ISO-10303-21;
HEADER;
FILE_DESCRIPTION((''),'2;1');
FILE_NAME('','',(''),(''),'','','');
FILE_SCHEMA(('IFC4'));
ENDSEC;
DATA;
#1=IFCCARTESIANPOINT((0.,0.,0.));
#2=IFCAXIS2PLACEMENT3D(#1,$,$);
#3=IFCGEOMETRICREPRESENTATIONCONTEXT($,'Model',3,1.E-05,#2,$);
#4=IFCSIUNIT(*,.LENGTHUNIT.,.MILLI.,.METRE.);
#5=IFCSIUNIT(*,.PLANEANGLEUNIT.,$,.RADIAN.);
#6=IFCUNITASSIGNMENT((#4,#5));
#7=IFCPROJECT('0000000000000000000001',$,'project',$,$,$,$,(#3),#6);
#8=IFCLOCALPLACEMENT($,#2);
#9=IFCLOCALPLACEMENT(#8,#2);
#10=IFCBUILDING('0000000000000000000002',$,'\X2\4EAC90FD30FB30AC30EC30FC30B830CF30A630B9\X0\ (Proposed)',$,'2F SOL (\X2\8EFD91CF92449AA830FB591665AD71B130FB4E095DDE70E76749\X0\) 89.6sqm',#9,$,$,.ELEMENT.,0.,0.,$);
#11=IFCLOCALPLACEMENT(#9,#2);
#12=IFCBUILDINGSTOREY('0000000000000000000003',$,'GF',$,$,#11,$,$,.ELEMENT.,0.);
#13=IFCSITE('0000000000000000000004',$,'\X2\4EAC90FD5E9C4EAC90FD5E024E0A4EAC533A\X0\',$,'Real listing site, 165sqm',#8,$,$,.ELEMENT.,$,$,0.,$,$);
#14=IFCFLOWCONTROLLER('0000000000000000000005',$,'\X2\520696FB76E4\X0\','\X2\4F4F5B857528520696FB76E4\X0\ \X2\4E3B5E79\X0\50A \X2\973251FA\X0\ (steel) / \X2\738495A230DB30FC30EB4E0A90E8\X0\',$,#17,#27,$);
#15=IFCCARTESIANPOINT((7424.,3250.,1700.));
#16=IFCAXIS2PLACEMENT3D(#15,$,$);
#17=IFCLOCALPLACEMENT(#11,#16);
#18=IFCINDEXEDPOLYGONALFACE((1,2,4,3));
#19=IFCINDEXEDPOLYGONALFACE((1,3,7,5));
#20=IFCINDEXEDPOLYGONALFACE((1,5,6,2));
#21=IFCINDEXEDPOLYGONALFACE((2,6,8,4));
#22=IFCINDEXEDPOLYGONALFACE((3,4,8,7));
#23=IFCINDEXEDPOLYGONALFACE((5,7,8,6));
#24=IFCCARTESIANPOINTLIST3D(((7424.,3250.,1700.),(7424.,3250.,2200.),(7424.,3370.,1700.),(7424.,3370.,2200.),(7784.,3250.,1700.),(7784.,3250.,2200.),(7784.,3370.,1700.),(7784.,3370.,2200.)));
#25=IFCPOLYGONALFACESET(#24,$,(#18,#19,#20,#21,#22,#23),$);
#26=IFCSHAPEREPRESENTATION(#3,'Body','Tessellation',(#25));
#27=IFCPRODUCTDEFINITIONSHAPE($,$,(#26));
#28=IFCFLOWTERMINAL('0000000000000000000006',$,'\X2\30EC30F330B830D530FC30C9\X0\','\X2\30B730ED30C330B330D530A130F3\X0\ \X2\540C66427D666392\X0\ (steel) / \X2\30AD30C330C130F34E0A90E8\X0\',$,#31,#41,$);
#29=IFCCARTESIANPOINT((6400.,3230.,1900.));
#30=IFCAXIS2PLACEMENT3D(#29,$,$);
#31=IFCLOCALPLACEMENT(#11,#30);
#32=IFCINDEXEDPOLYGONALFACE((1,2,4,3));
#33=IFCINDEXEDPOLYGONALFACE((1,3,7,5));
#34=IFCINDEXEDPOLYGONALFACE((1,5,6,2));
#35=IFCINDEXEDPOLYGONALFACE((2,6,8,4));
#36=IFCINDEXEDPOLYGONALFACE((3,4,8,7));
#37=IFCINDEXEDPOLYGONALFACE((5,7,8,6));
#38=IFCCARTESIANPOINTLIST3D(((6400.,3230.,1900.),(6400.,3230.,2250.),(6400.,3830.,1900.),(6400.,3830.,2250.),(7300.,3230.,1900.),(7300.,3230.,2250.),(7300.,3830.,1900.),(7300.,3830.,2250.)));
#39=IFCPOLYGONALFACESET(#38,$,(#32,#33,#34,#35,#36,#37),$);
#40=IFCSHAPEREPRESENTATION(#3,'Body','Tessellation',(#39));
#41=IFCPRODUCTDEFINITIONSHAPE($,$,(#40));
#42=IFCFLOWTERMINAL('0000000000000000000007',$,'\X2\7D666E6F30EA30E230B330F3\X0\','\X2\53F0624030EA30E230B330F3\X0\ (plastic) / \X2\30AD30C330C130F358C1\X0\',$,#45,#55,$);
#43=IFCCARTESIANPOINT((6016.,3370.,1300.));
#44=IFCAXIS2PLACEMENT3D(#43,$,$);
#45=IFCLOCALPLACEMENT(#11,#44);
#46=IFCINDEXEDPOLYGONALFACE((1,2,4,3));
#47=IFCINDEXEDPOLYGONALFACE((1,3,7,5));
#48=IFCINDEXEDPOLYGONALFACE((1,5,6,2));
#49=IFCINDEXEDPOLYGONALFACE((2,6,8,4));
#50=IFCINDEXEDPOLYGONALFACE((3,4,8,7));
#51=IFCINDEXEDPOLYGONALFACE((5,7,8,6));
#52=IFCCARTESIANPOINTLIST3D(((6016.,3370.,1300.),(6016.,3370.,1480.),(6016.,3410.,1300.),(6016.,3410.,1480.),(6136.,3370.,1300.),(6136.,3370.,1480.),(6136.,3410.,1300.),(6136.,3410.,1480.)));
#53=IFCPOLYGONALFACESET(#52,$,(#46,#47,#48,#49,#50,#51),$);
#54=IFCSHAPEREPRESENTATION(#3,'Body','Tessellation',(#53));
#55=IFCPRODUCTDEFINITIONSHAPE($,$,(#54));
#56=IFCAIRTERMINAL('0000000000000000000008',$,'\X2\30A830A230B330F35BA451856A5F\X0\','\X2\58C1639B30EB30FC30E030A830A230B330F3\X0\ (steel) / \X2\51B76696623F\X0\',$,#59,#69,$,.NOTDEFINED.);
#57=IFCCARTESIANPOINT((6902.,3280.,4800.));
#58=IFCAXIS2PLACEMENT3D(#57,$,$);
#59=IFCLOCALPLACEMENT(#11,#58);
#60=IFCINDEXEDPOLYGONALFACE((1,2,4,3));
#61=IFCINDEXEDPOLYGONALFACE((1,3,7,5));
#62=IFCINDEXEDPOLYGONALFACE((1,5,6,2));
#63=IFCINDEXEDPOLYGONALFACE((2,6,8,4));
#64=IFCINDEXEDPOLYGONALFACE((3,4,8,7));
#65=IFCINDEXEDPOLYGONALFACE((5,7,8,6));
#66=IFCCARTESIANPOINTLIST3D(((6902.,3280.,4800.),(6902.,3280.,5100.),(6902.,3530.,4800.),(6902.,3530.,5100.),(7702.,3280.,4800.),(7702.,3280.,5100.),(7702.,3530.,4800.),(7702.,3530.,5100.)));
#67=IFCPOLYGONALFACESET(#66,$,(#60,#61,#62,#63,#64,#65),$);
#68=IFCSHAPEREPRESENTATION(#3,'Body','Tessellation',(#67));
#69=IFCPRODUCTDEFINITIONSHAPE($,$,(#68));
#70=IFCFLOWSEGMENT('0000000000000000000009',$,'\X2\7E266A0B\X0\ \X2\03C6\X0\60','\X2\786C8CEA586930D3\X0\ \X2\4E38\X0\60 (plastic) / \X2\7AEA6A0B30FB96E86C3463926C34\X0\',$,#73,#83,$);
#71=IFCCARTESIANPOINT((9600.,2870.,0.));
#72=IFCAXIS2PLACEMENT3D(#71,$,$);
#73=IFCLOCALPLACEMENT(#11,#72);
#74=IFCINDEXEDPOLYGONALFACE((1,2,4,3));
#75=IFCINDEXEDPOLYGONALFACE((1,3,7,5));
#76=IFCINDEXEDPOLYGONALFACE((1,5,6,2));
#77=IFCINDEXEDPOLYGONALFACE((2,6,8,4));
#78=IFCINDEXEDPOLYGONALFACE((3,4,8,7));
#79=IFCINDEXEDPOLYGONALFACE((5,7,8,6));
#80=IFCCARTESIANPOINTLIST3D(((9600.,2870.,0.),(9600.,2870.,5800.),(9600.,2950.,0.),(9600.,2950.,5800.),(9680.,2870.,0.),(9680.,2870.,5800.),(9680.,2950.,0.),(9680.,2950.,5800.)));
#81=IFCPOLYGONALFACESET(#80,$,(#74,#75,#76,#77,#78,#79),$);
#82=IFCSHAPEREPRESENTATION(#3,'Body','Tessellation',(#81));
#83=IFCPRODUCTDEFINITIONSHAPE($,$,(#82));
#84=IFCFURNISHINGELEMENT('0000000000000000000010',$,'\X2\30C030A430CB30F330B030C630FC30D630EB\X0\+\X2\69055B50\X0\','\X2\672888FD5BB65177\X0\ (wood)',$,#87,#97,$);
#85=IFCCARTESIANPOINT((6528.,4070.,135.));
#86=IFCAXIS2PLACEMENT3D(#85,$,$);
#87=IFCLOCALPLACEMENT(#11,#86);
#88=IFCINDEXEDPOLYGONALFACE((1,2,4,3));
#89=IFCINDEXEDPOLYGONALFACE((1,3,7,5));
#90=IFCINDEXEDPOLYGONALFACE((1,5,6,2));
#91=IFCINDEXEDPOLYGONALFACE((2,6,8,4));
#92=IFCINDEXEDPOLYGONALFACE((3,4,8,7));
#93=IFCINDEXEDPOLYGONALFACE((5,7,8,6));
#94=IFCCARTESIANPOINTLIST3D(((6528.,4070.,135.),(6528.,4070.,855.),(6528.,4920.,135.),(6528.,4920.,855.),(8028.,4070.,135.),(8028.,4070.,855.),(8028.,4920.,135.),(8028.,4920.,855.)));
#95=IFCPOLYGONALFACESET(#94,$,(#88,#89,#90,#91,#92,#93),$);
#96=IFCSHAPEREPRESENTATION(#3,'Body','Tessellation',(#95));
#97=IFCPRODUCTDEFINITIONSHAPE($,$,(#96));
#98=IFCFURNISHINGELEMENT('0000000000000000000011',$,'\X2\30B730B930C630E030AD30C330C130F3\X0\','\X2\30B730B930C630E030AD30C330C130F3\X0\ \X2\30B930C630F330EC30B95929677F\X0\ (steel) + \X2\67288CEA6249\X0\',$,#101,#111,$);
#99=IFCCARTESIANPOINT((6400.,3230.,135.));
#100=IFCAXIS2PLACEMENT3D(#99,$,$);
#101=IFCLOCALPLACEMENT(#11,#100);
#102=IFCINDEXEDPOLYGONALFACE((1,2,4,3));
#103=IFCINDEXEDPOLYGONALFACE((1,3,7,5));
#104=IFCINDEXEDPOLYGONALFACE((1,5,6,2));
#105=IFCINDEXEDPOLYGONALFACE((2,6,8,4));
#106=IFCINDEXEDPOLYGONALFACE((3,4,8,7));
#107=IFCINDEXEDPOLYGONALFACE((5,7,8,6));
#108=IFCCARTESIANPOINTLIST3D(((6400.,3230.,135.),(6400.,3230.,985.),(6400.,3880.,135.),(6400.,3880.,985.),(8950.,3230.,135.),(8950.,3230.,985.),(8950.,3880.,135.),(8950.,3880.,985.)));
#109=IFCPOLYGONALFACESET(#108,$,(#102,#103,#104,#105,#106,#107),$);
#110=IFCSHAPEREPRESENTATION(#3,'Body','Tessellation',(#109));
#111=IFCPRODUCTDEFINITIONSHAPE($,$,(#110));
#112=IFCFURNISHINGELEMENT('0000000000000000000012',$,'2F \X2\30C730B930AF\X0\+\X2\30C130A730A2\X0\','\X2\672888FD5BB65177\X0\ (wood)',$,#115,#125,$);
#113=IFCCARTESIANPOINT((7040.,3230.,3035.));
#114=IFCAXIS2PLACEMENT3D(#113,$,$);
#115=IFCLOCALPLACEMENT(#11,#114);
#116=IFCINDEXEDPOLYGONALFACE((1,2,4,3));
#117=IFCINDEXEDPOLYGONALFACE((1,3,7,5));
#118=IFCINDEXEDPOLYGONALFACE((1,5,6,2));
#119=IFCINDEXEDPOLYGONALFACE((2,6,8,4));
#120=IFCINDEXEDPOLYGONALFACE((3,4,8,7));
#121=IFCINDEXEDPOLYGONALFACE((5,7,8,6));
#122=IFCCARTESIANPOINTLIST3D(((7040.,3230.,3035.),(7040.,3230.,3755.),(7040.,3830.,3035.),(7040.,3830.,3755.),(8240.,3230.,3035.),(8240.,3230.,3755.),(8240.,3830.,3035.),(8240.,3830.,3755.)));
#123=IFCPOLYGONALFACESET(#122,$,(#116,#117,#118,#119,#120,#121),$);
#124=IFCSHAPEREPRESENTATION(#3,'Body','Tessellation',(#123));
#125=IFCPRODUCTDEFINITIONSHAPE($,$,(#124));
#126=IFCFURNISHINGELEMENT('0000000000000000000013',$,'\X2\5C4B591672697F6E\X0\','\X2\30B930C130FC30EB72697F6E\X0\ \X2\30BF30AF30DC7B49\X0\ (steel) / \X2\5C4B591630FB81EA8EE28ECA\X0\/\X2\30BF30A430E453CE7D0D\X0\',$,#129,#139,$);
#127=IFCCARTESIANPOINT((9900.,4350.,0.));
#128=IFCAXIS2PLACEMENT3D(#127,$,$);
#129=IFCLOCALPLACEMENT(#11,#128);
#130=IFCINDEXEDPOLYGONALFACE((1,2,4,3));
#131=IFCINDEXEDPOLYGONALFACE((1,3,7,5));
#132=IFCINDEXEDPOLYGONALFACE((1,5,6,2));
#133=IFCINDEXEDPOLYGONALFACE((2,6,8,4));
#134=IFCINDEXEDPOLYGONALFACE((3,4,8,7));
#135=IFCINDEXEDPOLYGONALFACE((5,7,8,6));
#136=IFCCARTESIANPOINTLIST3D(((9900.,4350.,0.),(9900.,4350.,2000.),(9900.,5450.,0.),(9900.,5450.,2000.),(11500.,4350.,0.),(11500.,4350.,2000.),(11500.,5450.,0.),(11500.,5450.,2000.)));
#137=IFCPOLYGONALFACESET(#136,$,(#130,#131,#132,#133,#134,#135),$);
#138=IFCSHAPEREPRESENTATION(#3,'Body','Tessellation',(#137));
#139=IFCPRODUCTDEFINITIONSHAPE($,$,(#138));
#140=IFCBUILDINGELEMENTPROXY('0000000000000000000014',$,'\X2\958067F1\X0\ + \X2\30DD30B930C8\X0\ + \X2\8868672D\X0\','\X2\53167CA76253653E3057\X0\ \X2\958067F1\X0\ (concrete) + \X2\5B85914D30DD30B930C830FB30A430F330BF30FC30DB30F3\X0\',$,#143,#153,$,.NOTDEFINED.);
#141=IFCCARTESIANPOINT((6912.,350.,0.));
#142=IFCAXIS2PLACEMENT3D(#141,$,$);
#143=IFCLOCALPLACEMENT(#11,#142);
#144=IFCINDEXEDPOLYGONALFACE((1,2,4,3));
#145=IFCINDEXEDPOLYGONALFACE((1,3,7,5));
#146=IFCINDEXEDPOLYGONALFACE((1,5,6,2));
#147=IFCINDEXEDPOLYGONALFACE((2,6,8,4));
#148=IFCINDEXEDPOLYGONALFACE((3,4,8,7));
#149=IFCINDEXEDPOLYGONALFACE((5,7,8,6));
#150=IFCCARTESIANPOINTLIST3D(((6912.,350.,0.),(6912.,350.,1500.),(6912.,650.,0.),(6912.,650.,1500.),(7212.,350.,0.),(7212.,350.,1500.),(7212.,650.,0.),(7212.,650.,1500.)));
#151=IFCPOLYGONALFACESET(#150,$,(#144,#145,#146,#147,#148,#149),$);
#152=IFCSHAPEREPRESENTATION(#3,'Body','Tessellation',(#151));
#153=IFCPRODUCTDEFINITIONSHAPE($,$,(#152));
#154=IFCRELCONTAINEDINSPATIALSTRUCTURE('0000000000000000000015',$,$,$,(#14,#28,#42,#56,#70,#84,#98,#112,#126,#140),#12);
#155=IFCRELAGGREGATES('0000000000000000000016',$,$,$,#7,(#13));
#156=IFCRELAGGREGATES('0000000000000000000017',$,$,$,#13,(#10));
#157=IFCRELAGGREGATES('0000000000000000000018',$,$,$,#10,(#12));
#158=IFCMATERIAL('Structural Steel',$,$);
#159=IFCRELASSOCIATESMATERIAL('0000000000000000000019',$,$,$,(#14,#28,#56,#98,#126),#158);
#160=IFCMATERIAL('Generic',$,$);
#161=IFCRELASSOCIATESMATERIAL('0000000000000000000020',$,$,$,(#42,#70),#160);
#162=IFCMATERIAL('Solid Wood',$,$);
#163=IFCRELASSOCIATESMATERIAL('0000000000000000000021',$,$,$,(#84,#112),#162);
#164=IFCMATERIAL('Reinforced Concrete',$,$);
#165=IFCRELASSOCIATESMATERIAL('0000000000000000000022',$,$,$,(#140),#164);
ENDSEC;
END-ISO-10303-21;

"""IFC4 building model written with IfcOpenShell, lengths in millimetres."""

from ifc_helpers import new_model, si_unit, frame, frame_2d, origin, place, context, project, spatial, rectangle, extrude, material, element, save


model = new_model("IFC4")

# Units and contexts
model_context = context("Model", 3, precision=1e-05, world=origin())
ifc_project = project(units=[si_unit("LENGTHUNIT", "METRE", prefix="MILLI"), si_unit("PLANEANGLEUNIT", "RADIAN")], contexts=[model_context])

# Site, building, storey
site_placement = place(None, origin())
site = spatial("IfcSite", under=ifc_project, at=site_placement, Name="京都府京都市上京区", ObjectType="Real listing site, 165sqm", CompositionType="ELEMENT", RefElevation=0.0)
building_placement = place(site_placement, origin())
building = spatial("IfcBuilding", under=site, at=building_placement, Name="京都・ガレージハウス (Proposed)", ObjectType="2F SOL (軽量鉄骨・外断熱・三州烧杉) 89.6sqm", CompositionType="ELEMENT", ElevationOfRefHeight=0.0, ElevationOfTerrain=0.0)
storey_placement = place(building_placement, origin())
storey = spatial("IfcBuildingStorey", under=building, at=storey_placement, Name="GF", CompositionType="ELEMENT", Elevation=0.0)

# Shared definitions
ifc_material_1 = material(Name="Solid Wood")
ifc_material_2 = material(Name="Structural Steel")

# Shared definitions
ifc_material_3 = material(Name="Reinforced Concrete")

# Flow controller
flow_controller_placement = place(storey_placement, frame((7424.0, 3250.0, 1700.0)))
element("IfcFlowController", 1, at=flow_controller_placement, inside=storey, material=ifc_material_2, Name="分電盤", Description="住宅用分電盤 主幹50A 露出 (steel) / 玄関ホール上部", context=model_context, shape_type="SweptSolid", body=[
    extrude(rectangle(XDim=360.0, YDim=120.0, at=frame_2d((180.0, 60.0))), frame((7424.0, 3250.0, 1700.0)), (0.0, 0.0, 1.0), 500.0),
])

# Flow terminals
flow_terminal_1_placement = place(storey_placement, frame((6400.0, 3230.0, 1900.0)))
element("IfcFlowTerminal", 2, at=flow_terminal_1_placement, inside=storey, material=ifc_material_2, Name="レンジフード", Description="シロッコファン 同時給排 (steel) / キッチン上部", context=model_context, shape_type="SweptSolid", body=[
    extrude(rectangle(XDim=900.0, YDim=600.0, at=frame_2d((450.0, 300.0))), frame((6400.0, 3230.0, 1900.0)), (0.0, 0.0, 1.0), 350.0),
])
ifc_material_4 = material(Name="Generic")
flow_terminal_2_placement = place(storey_placement, frame((6016.0, 3370.0, 1300.0)))
element("IfcFlowTerminal", 3, at=flow_terminal_2_placement, inside=storey, material=ifc_material_4, Name="給湯リモコン", Description="台所リモコン (plastic) / キッチン壁", context=model_context, shape_type="SweptSolid", body=[
    extrude(rectangle(XDim=120.0, YDim=40.0, at=frame_2d((60.0, 20.0))), frame((6016.0, 3370.0, 1300.0)), (0.0, 0.0, 1.0), 180.0),
])

# Air terminal
air_terminal_placement = place(storey_placement, frame((6902.0, 3280.0, 4800.0)))
element("IfcAirTerminal", 4, at=air_terminal_placement, inside=storey, material=ifc_material_2, Name="エアコン室内機", Description="壁掛ルームエアコン (steel) / 冷暖房", PredefinedType="NOTDEFINED", context=model_context, shape_type="SweptSolid", body=[
    extrude(rectangle(XDim=800.0, YDim=250.0, at=frame_2d((400.0, 125.0))), frame((6902.0, 3280.0, 4800.0)), (0.0, 0.0, 1.0), 300.0),
])

# Flow segment
flow_segment_placement = place(storey_placement, frame((9600.0, 2870.0, 0.0)))
element("IfcFlowSegment", 5, at=flow_segment_placement, inside=storey, material=ifc_material_4, Name="縦樋 φ60", Description="硬質塩ビ 丸60 (plastic) / 竪樋・雨水排水", context=model_context, shape_type="SweptSolid", body=[
    extrude(rectangle(XDim=80.0, YDim=80.0, at=frame_2d((40.0, 40.0))), frame((9600.0, 2870.0, 0.0)), (0.0, 0.0, 1.0), 5800.0),
])

# Furnishing elements
furnishing_1_placement = place(storey_placement, frame((6528.0, 4070.0, 135.0)))
element("IfcFurnishingElement", 6, at=furnishing_1_placement, inside=storey, material=ifc_material_1, Name="ダイニングテーブル+椅子", Description="木製家具 (wood)", context=model_context, shape_type="SweptSolid", body=[
    extrude(rectangle(XDim=1500.0, YDim=850.0, at=frame_2d((750.0, 425.0))), frame((6528.0, 4070.0, 135.0)), (0.0, 0.0, 1.0), 720.0),
])
furnishing_2_placement = place(storey_placement, frame((6400.0, 3230.0, 135.0)))
element("IfcFurnishingElement", 7, at=furnishing_2_placement, inside=storey, material=ifc_material_2, Name="システムキッチン", Description="システムキッチン ステンレス天板 (steel) + 木質扉", context=model_context, shape_type="SweptSolid", body=[
    extrude(rectangle(XDim=2550.0, YDim=650.0, at=frame_2d((1275.0, 325.0))), frame((6400.0, 3230.0, 135.0)), (0.0, 0.0, 1.0), 850.0),
])
furnishing_3_placement = place(storey_placement, frame((7040.0, 3230.0, 3035.0)))
element("IfcFurnishingElement", 8, at=furnishing_3_placement, inside=storey, material=ifc_material_1, Name="2F デスク+チェア", Description="木製家具 (wood)", context=model_context, shape_type="SweptSolid", body=[
    extrude(rectangle(XDim=1200.0, YDim=600.0, at=frame_2d((600.0, 300.0))), frame((7040.0, 3230.0, 3035.0)), (0.0, 0.0, 1.0), 720.0),
])
furnishing_4_placement = place(storey_placement, frame((9900.0, 4350.0, 0.0)))
element("IfcFurnishingElement", 9, at=furnishing_4_placement, inside=storey, material=ifc_material_2, Name="屋外物置", Description="スチール物置 タクボ等 (steel) / 屋外・自転車/タイヤ収納", context=model_context, shape_type="SweptSolid", body=[
    extrude(rectangle(XDim=1600.0, YDim=1100.0, at=frame_2d((800.0, 550.0))), frame((9900.0, 4350.0, 0.0)), (0.0, 0.0, 1.0), 2000.0),
])

# Building element proxy
proxy_placement = place(storey_placement, frame((6912.0, 350.0, 0.0)))
element("IfcBuildingElementProxy", 10, at=proxy_placement, inside=storey, material=ifc_material_3, Name="門柱 + ポスト + 表札", Description="化粧打放し 門柱 (concrete) + 宅配ポスト・インターホン", PredefinedType="NOTDEFINED", context=model_context, shape_type="SweptSolid", body=[
    extrude(rectangle(XDim=300.0, YDim=300.0, at=frame_2d((150.0, 150.0))), frame((6912.0, 350.0, 0.0)), (0.0, 0.0, 1.0), 1500.0),
])

save(model, "model.ifc")
